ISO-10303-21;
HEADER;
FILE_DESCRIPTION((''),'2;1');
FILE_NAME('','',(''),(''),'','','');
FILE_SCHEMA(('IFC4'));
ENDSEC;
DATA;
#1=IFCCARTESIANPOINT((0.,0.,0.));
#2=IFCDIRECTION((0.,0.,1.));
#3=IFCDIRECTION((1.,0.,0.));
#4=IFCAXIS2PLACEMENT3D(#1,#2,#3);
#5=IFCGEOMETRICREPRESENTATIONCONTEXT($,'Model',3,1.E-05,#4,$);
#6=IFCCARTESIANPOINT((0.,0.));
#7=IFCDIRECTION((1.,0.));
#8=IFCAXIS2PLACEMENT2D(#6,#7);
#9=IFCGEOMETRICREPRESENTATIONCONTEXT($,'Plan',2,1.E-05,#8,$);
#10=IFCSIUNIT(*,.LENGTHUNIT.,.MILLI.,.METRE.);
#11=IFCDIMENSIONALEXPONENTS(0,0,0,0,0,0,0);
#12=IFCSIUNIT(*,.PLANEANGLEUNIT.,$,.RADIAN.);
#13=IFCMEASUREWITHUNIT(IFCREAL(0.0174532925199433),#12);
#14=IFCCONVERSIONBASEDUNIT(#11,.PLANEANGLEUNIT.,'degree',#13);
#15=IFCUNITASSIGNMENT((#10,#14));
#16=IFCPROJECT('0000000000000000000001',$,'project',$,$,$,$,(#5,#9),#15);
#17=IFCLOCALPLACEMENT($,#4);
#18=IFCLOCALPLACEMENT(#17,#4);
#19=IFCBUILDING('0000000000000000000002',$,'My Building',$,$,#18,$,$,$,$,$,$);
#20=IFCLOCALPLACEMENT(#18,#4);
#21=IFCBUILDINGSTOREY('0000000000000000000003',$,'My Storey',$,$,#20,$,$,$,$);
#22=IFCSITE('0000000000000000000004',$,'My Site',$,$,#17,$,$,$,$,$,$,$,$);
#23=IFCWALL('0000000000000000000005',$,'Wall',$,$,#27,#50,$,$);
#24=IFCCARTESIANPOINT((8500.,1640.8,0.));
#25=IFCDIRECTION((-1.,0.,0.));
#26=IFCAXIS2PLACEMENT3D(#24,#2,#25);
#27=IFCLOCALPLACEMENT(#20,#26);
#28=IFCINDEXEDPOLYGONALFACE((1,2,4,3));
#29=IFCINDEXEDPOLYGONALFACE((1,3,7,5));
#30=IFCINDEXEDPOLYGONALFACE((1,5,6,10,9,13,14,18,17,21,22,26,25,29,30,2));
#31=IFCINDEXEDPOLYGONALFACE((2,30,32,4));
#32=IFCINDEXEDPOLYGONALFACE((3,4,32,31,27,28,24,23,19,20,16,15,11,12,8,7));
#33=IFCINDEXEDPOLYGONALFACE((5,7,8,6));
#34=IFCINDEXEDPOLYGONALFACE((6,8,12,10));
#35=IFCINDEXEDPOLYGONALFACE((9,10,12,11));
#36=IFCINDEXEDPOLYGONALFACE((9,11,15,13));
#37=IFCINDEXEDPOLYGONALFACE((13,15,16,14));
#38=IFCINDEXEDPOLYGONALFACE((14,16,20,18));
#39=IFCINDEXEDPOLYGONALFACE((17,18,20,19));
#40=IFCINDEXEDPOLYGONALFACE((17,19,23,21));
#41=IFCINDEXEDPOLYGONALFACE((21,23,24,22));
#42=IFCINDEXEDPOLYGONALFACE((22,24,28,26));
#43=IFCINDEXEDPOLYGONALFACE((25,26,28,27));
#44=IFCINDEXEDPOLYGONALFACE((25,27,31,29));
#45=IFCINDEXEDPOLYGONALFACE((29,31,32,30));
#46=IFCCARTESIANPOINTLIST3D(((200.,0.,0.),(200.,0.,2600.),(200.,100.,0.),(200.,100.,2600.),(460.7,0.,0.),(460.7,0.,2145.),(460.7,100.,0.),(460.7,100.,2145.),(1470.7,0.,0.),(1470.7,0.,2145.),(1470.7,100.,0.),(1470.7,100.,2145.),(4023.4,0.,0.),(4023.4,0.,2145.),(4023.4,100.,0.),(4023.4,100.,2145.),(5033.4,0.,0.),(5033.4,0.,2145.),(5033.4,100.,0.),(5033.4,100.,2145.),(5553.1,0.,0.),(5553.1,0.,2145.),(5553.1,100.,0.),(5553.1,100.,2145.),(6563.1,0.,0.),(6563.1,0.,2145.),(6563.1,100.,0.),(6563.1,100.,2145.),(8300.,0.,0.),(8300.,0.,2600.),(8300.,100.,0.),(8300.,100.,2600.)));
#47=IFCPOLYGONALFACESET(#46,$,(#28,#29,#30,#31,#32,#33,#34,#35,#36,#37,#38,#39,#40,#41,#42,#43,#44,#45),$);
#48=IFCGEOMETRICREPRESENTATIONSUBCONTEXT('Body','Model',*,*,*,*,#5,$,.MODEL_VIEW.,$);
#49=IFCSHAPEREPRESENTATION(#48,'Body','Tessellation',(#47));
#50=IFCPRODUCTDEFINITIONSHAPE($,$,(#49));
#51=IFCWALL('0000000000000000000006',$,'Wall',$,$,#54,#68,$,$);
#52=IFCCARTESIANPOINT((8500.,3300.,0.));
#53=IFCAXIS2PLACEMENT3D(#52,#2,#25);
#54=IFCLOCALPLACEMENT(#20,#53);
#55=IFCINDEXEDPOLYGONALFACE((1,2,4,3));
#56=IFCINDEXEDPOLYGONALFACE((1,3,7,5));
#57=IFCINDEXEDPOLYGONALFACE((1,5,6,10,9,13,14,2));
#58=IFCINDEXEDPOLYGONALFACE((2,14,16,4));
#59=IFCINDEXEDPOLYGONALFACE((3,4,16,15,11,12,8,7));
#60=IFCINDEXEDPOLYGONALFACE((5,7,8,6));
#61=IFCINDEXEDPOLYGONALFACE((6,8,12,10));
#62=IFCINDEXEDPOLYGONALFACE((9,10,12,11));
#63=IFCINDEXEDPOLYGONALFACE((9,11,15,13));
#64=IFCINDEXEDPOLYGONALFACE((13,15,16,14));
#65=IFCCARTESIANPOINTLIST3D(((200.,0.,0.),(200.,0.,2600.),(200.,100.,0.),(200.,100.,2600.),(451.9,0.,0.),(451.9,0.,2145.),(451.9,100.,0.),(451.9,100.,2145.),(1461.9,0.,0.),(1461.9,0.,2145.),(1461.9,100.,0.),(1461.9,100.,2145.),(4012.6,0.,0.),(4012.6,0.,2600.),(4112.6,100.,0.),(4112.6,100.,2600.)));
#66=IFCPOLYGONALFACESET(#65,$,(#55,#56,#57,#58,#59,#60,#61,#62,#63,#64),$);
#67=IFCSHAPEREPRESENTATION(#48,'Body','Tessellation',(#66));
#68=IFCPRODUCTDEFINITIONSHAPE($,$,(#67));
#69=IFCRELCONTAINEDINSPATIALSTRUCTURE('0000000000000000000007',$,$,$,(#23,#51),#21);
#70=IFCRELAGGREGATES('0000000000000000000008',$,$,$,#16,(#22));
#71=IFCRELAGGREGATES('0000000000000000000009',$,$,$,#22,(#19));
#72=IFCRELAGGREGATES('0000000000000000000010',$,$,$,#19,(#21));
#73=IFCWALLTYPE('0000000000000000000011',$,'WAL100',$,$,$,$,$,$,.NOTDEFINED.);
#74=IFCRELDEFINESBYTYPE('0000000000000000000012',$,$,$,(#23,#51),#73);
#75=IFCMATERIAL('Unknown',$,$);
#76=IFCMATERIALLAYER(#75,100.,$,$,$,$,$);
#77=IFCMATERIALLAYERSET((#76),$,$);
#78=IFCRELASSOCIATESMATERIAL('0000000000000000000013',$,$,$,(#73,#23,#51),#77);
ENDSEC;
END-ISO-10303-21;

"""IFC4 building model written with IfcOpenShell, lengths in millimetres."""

from ifc_helpers import new_model, entity, si_unit, converted_unit, frame, origin_with_axes, origin_2d_with_axis, place, context, subcontext, project, spatial, line, indexed_curve, outline, extrude, source, transform, mapped, material, layer, layer_set, layer_usage, type_object, element, save


model = new_model("IFC4")

# Units and contexts
model_context = context("Model", 3, precision=1e-05, world=origin_with_axes())
plan_context = context("Plan", 2, precision=1e-05, world=origin_2d_with_axis())
body_context = subcontext(model_context, "Body", "Model", "MODEL_VIEW")
ifc_project = project(units=[si_unit("LENGTHUNIT", "METRE", prefix="MILLI"), converted_unit("PLANEANGLEUNIT", "degree", entity("IfcReal", 0.0174532925199433), si_unit("PLANEANGLEUNIT", "RADIAN"), dimensions=[0, 0, 0, 0, 0, 0, 0])], contexts=[model_context, plan_context])

# Site, building, storey
site_placement = place(None, origin_with_axes())
site = spatial("IfcSite", under=ifc_project, at=site_placement, Name="My Site")
building_placement = place(site_placement, origin_with_axes())
building = spatial("IfcBuilding", under=site, at=building_placement, Name="My Building")
storey_placement = place(building_placement, origin_with_axes())
storey = spatial("IfcBuildingStorey", under=building, at=storey_placement, Name="My Storey")

# Shared definitions
ifc_material = material(Name="Unknown")

# Shared definitions
ifc_layer_1 = layer(ifc_material, 100.0)
ifc_layer_set_1 = layer_set([ifc_layer_1])
wall_type_1 = type_object("IfcWallType", Name="WAL100", PredefinedType="NOTDEFINED", material=ifc_layer_set_1)

# Wall, openings
ifc_layer_usage_1 = layer_usage(ifc_layer_set_1, "AXIS2", "POSITIVE", 0.0)
wall_1_placement = place(storey_placement, frame((8500.0, 1640.8, 0.0), z_axis=(0.0, 0.0, 1.0), x_axis=(-1.0, 0.0, 0.0)))
wall_1 = element("IfcWall", 1, at=wall_1_placement, inside=storey, type_object=wall_type_1, material=ifc_layer_usage_1, Name="Wall", context=body_context, shape_type="SweptSolid", body=[
    extrude(outline(indexed_curve([(200.0, 0.0), (200.0, 100.0), (8300.0, 100.0), (8300.0, 0.0)], segments=[line(1, 2, 3, 4, 1)])), origin_with_axes(), (0.0, 0.0, 1.0), 2600.0),
])
shared_shape_1 = source(origin_with_axes(), body_context, "Body", "SweptSolid", [
    extrude(outline(indexed_curve([(0.0, 0.0), (1010.0, 0.0), (1010.0, 2145.0), (0.0, 2145.0)], segments=[line(1, 2, 3, 4, 1)])), frame((0.0, -600.0, 0.0), z_axis=(0.0, -1.0, 0.0), x_axis=(1.0, 0.0, 0.0)), (0.0, 0.0, -1.0), 1200.0),
])
opening_1_placement = place(wall_1_placement, frame((5553.1, 0.0, 0.0), z_axis=(0.0, 0.0, 1.0), x_axis=(1.0, 0.0, 0.0)))
element("IfcOpeningElement", 2, at=opening_1_placement, cuts=wall_1, PredefinedType="OPENING", context=body_context, shape_type="MappedRepresentation", body=[
    mapped(shared_shape_1, transform((0.0, 0.0, 0.0), x_axis=(1.0, 0.0, 0.0), y_axis=(0.0, 1.0, 0.0), z_axis=(0.0, 0.0, 1.0), scale=1.0)),
])
opening_2_placement = place(wall_1_placement, frame((460.7, 0.0, 0.0), z_axis=(0.0, 0.0, 1.0), x_axis=(1.0, 0.0, 0.0)))
element("IfcOpeningElement", 3, at=opening_2_placement, cuts=wall_1, PredefinedType="OPENING", context=body_context, shape_type="MappedRepresentation", body=[
    mapped(shared_shape_1, transform((0.0, 0.0, 0.0), x_axis=(1.0, 0.0, 0.0), y_axis=(0.0, 1.0, 0.0), z_axis=(0.0, 0.0, 1.0), scale=1.0)),
])
opening_3_placement = place(wall_1_placement, frame((4023.4, 0.0, 0.0), z_axis=(0.0, 0.0, 1.0), x_axis=(1.0, 0.0, 0.0)))
element("IfcOpeningElement", 4, at=opening_3_placement, cuts=wall_1, PredefinedType="OPENING", context=body_context, shape_type="MappedRepresentation", body=[
    mapped(shared_shape_1, transform((0.0, 0.0, 0.0), x_axis=(1.0, 0.0, 0.0), y_axis=(0.0, 1.0, 0.0), z_axis=(0.0, 0.0, 1.0), scale=1.0)),
])

# Wall, opening
ifc_layer_usage_2 = layer_usage(ifc_layer_set_1, "AXIS2", "POSITIVE", 0.0)
wall_2_placement = place(storey_placement, frame((8500.0, 3300.0, 0.0), z_axis=(0.0, 0.0, 1.0), x_axis=(-1.0, 0.0, 0.0)))
wall_2 = element("IfcWall", 5, at=wall_2_placement, inside=storey, type_object=wall_type_1, material=ifc_layer_usage_2, Name="Wall", context=body_context, shape_type="SweptSolid", body=[
    extrude(outline(indexed_curve([(200.0, 0.0), (200.0, 100.0), (4112.6, 100.0), (4012.6, 0.0)], segments=[line(1, 2, 3, 4, 1)])), origin_with_axes(), (0.0, 0.0, 1.0), 2600.0),
])
opening_4_placement = place(wall_2_placement, frame((451.9, 0.0, 0.0), z_axis=(0.0, 0.0, 1.0), x_axis=(1.0, 0.0, 0.0)))
element("IfcOpeningElement", 6, at=opening_4_placement, cuts=wall_2, PredefinedType="OPENING", context=body_context, shape_type="MappedRepresentation", body=[
    mapped(shared_shape_1, transform((0.0, 0.0, 0.0), x_axis=(1.0, 0.0, 0.0), y_axis=(0.0, 1.0, 0.0), z_axis=(0.0, 0.0, 1.0), scale=1.0)),
])

save(model, "model.ifc")
